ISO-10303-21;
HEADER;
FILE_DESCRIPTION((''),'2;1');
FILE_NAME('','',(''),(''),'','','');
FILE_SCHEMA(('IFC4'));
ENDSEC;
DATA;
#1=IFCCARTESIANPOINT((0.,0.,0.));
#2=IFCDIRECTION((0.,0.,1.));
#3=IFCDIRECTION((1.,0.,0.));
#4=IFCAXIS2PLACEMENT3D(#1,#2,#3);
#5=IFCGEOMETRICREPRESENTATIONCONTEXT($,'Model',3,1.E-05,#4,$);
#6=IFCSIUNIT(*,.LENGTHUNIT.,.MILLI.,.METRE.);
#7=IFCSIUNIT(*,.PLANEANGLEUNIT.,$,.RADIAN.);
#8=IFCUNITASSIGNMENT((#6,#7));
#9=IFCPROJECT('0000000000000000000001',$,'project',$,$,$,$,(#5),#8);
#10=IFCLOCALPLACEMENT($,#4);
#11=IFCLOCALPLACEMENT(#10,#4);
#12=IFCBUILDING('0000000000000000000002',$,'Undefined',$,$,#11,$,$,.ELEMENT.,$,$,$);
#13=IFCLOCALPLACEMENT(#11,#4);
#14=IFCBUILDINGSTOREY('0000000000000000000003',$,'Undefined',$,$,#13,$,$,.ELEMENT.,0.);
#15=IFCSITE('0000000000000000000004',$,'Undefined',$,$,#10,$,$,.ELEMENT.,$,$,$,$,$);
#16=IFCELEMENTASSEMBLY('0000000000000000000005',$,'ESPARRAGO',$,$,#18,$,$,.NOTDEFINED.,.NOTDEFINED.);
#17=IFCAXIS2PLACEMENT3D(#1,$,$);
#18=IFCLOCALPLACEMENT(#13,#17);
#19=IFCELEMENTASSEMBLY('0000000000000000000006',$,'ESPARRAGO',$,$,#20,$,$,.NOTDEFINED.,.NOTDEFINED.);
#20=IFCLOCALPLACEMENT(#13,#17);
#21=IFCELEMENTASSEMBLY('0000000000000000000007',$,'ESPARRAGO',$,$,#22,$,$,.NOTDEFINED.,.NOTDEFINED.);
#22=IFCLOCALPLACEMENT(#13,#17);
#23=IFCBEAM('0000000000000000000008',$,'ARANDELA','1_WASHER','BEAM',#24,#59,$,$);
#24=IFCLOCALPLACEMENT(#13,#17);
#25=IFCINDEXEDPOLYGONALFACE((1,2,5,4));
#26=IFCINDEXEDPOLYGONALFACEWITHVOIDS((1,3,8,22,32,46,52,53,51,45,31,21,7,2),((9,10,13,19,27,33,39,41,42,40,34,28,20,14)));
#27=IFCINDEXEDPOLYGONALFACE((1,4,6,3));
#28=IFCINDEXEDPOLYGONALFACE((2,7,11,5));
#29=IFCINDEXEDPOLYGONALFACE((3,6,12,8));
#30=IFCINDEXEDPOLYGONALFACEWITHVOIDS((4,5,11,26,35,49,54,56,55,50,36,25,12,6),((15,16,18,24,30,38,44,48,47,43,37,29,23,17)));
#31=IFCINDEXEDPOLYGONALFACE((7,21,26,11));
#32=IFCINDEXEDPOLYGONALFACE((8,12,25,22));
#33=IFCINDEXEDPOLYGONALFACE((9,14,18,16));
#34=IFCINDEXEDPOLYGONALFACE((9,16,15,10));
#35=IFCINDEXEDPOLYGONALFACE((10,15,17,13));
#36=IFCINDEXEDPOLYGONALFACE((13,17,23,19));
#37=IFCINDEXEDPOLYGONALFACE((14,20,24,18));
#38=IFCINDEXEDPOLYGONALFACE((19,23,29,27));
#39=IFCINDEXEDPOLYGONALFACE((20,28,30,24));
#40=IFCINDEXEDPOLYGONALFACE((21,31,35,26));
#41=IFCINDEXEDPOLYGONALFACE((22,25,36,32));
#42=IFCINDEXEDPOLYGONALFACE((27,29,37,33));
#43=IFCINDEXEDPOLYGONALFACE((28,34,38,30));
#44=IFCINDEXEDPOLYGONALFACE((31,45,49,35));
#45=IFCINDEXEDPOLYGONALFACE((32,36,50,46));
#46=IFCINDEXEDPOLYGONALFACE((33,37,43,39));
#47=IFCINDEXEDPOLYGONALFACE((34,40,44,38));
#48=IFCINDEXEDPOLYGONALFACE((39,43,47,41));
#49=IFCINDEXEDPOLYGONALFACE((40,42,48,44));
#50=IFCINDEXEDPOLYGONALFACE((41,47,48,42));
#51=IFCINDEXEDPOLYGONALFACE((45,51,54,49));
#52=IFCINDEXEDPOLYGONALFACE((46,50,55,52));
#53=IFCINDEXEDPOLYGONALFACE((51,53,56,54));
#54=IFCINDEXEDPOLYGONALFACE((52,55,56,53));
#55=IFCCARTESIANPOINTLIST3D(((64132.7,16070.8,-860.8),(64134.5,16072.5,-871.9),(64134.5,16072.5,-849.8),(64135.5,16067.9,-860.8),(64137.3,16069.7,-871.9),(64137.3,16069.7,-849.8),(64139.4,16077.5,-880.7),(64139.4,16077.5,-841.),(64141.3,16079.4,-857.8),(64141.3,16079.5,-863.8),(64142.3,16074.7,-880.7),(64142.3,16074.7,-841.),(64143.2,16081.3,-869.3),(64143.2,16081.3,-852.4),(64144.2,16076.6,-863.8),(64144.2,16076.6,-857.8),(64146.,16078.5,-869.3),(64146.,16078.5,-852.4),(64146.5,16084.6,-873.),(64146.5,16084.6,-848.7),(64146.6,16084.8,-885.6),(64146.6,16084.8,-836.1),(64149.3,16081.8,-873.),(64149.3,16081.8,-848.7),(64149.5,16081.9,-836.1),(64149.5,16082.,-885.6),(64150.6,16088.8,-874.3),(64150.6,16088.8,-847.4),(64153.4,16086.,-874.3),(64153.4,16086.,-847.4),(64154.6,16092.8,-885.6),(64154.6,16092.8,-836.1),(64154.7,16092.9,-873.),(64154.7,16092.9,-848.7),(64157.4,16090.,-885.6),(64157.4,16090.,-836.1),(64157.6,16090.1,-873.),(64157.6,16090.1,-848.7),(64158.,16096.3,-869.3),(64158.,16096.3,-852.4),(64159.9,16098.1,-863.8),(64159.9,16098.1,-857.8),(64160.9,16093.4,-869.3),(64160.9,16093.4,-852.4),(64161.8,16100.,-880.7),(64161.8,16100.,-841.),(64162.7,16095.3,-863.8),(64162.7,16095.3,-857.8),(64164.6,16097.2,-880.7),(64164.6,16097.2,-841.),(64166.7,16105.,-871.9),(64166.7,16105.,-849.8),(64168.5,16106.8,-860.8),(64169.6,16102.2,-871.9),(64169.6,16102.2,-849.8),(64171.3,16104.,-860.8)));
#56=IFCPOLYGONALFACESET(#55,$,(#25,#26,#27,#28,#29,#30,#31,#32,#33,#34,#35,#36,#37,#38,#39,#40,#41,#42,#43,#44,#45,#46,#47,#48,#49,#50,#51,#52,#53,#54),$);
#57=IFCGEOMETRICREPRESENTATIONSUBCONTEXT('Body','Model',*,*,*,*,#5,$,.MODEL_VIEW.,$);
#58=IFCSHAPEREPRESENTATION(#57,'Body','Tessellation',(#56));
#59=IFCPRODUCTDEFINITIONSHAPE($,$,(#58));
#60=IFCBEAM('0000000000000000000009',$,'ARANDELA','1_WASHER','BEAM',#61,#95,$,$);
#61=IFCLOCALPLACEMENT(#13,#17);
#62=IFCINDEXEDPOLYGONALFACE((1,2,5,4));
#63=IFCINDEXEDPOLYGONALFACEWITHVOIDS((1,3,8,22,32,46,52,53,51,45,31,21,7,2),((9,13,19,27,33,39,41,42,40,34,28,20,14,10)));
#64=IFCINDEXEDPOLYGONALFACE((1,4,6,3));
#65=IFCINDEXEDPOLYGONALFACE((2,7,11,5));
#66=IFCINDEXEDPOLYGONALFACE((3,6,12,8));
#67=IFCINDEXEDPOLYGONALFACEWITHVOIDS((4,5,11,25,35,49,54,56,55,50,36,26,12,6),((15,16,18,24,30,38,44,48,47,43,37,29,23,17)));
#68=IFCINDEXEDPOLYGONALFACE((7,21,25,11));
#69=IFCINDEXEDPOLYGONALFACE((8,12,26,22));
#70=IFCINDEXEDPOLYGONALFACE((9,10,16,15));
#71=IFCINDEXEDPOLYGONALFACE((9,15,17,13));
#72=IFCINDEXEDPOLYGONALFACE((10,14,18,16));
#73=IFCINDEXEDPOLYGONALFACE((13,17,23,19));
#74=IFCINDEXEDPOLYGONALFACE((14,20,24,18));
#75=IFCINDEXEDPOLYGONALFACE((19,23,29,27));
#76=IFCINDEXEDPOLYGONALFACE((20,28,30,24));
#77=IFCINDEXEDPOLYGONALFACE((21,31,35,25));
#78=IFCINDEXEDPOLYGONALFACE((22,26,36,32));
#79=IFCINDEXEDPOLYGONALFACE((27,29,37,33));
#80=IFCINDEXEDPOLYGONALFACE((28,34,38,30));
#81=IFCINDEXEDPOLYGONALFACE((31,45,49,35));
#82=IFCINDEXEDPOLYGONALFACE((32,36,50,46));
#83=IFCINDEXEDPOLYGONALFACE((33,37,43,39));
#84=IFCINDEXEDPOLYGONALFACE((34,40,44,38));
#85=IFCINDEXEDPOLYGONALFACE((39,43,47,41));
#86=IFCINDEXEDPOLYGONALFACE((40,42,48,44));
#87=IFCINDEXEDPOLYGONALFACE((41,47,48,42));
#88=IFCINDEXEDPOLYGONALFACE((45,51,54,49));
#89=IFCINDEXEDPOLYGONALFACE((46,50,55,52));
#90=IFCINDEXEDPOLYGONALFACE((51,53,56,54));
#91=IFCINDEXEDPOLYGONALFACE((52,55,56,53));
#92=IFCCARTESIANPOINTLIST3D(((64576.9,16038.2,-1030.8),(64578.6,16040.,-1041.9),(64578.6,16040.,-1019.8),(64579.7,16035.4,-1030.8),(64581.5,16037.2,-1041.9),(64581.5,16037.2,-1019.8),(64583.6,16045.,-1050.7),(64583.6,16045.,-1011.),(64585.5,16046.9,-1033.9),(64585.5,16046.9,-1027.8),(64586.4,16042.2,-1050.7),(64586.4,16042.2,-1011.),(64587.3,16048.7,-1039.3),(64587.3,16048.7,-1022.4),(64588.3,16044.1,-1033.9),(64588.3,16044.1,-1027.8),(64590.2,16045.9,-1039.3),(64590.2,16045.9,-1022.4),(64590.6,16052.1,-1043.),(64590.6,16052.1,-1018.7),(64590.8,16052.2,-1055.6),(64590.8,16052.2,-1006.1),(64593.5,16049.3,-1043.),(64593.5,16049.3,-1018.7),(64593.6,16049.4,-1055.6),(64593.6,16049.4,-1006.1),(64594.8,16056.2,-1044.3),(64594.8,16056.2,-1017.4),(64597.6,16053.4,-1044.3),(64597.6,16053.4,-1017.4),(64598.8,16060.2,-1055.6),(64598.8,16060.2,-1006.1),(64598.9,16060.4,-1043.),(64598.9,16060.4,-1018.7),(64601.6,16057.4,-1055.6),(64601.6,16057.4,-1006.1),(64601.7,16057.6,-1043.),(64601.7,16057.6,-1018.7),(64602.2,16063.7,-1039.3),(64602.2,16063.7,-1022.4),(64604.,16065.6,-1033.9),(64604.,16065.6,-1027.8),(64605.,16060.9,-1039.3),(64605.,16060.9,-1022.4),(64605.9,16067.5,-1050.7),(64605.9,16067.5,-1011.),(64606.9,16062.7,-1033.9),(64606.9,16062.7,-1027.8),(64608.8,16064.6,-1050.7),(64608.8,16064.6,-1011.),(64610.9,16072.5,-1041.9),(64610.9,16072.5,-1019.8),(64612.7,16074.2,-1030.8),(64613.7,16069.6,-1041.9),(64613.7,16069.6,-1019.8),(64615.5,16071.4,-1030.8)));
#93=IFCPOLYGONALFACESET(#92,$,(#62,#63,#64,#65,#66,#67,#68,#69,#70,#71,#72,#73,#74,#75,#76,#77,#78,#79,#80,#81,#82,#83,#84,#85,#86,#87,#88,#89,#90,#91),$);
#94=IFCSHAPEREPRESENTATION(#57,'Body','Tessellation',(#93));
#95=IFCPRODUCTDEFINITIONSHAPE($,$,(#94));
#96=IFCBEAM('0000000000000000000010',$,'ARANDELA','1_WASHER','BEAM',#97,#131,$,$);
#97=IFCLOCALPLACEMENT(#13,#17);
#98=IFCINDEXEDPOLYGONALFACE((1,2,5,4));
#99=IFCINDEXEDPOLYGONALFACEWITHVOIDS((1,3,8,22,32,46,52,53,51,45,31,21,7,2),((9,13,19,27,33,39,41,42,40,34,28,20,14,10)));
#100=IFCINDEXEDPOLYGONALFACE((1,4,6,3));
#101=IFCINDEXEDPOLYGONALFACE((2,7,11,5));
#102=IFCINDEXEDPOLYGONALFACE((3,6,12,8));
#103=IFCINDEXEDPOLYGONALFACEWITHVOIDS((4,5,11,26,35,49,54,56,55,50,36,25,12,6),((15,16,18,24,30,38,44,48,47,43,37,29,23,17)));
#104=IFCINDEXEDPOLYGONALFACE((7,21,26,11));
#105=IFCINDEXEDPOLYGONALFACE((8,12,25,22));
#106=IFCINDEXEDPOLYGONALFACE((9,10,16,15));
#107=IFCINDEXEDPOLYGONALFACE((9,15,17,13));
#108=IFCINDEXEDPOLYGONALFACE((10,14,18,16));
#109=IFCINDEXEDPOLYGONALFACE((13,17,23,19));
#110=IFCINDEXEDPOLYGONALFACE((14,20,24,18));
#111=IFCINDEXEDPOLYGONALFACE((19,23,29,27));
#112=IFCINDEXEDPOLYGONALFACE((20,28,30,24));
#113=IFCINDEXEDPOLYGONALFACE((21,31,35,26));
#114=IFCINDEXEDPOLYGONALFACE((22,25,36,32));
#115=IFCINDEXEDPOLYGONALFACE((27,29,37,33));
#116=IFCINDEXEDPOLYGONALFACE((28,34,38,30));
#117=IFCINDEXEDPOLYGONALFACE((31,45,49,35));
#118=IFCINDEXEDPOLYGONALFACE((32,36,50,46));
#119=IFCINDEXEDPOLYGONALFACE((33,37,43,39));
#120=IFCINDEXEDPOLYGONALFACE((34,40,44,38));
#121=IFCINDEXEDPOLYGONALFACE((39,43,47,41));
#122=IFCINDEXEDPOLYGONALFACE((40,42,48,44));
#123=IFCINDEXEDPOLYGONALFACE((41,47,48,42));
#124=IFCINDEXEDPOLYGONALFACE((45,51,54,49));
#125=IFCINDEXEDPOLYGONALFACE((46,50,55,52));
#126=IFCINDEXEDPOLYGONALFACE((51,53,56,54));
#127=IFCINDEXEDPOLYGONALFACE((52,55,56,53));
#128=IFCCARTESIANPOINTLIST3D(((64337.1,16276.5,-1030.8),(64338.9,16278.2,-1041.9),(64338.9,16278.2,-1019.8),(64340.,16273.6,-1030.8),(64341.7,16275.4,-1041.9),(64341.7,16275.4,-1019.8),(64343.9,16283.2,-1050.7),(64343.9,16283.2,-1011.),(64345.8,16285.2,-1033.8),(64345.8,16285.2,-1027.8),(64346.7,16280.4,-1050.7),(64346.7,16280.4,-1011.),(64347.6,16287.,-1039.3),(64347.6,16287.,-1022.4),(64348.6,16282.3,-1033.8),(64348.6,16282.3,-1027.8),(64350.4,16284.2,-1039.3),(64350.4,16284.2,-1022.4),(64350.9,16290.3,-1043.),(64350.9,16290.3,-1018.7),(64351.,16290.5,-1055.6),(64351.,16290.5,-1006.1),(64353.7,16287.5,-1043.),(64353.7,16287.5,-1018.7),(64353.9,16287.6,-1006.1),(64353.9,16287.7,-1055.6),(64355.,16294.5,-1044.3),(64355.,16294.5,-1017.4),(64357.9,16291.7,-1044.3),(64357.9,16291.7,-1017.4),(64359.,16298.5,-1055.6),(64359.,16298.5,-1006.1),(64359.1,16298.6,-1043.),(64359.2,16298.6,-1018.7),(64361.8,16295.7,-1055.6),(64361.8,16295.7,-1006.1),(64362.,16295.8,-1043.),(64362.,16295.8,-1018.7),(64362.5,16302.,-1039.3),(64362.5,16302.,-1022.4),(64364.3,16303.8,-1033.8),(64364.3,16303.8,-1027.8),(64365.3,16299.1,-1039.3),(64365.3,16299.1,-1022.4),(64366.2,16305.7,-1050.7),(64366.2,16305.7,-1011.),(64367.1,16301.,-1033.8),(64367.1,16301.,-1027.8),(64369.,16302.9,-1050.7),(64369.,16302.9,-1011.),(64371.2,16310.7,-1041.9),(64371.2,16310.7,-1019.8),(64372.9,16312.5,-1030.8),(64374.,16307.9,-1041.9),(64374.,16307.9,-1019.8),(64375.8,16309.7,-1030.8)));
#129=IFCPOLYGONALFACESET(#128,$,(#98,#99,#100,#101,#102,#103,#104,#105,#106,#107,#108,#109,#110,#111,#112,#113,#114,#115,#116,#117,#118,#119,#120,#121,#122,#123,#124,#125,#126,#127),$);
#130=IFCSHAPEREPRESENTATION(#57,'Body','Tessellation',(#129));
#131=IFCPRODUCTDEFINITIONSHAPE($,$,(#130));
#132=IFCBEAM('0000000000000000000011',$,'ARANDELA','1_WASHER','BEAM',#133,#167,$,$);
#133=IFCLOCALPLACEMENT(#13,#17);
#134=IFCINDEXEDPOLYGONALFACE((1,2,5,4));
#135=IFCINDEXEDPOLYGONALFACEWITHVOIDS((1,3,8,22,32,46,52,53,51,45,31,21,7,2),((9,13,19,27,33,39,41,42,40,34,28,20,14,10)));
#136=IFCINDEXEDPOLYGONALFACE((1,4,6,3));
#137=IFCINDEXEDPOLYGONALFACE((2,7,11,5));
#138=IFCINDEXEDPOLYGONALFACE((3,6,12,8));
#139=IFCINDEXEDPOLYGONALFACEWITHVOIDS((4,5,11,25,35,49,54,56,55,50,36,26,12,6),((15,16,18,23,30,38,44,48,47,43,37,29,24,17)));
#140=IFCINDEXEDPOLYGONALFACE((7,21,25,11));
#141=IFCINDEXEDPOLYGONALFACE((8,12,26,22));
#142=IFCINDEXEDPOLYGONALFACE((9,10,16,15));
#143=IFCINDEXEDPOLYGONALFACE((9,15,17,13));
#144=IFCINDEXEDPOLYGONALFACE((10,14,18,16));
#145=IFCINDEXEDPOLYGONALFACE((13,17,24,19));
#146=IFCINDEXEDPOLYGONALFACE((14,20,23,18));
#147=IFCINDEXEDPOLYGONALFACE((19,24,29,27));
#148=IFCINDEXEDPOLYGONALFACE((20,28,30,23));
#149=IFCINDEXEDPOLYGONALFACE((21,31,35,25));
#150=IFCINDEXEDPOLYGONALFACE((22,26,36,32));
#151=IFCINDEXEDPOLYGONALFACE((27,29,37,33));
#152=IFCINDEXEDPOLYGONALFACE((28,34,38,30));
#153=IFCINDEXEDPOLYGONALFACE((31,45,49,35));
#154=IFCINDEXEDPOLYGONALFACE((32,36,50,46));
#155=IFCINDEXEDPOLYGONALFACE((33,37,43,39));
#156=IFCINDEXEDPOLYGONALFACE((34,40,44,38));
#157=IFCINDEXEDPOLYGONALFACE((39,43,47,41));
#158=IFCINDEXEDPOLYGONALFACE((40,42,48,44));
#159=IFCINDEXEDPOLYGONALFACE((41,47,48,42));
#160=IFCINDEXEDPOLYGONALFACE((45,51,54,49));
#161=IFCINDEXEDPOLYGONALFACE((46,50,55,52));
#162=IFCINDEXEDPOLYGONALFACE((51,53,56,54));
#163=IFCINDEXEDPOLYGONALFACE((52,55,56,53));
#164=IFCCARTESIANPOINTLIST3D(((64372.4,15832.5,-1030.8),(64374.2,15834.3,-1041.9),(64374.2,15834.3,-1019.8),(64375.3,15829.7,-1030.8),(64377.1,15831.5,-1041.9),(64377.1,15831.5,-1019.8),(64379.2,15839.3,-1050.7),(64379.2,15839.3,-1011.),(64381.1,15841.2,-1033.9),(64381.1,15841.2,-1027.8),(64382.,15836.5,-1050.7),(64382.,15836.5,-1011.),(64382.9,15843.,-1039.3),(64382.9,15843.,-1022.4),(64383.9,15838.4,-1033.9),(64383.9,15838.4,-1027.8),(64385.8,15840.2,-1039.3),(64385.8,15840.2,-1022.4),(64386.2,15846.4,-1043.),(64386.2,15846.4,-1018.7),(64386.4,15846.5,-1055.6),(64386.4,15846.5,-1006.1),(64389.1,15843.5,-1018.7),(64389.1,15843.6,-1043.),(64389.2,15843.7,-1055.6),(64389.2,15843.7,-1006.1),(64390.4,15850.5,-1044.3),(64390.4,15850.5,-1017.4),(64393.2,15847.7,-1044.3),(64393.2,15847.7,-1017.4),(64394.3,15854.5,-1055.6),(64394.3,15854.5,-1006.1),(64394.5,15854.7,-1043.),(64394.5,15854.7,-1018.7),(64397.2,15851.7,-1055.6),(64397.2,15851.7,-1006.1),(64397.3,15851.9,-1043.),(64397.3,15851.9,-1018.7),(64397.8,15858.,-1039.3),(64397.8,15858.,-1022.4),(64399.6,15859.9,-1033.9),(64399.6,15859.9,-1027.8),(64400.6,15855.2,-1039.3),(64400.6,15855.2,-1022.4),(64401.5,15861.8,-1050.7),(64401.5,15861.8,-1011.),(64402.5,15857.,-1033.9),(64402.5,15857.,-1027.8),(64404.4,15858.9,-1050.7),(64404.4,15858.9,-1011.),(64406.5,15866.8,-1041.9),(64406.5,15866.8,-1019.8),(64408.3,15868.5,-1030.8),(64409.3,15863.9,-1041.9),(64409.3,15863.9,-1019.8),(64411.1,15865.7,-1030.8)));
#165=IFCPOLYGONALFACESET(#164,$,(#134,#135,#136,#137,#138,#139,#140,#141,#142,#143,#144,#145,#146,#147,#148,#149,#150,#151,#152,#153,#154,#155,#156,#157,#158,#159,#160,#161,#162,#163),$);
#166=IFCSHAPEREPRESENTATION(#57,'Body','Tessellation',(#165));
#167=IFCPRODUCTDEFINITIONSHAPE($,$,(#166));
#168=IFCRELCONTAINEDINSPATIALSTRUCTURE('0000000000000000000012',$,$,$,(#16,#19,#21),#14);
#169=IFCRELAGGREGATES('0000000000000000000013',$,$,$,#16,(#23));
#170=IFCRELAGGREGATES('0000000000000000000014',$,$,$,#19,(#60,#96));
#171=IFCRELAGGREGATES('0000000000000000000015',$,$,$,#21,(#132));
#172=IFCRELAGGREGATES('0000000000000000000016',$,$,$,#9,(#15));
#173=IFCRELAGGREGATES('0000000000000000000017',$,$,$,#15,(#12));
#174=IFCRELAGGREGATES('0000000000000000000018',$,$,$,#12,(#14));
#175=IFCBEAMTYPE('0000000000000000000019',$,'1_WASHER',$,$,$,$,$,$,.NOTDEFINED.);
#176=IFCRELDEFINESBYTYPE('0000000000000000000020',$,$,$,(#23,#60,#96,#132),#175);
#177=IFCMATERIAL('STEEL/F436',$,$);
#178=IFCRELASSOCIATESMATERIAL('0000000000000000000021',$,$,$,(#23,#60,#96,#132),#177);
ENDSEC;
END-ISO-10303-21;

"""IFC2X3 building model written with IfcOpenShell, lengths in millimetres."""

from ifc_helpers import new_model, si_unit, frame, origin_with_axes, place, context, subcontext, project, spatial, polyline, outline, extrude, material, type_object, element, aggregate, save


model = new_model("IFC2X3")

# Units and contexts
model_context = context("Model", 3, precision=1e-05, world=origin_with_axes())
body_context = subcontext(model_context, "Body", "Model", "MODEL_VIEW")
ifc_project = project(units=[si_unit("LENGTHUNIT", "METRE", prefix="MILLI"), si_unit("PLANEANGLEUNIT", "RADIAN")], contexts=[model_context])

# Site, building, storey
site_placement = place(None, origin_with_axes())
site = spatial("IfcSite", under=ifc_project, at=site_placement, Name="Undefined", CompositionType="ELEMENT")
building_placement = place(site_placement, origin_with_axes())
building = spatial("IfcBuilding", under=site, at=building_placement, Name="Undefined", CompositionType="ELEMENT")
storey_placement = place(building_placement, origin_with_axes())
storey = spatial("IfcBuildingStorey", under=building, at=storey_placement, Name="Undefined", CompositionType="ELEMENT", Elevation=0.0)

# Element assemblies
assembly_1_placement = place(storey_placement, origin_with_axes())
assembly_1 = element("IfcElementAssembly", 1, at=assembly_1_placement, inside=storey, Name="ESPARRAGO", AssemblyPlace="NOTDEFINED", PredefinedType="NOTDEFINED")
assembly_2_placement = place(storey_placement, origin_with_axes())
assembly_2 = element("IfcElementAssembly", 2, at=assembly_2_placement, inside=storey, Name="ESPARRAGO", AssemblyPlace="NOTDEFINED", PredefinedType="NOTDEFINED")
assembly_3_placement = place(storey_placement, origin_with_axes())
assembly_3 = element("IfcElementAssembly", 3, at=assembly_3_placement, inside=storey, Name="ESPARRAGO", AssemblyPlace="NOTDEFINED", PredefinedType="NOTDEFINED")

# Beams
ifc_material_1 = material(Name="STEEL/F436")
beam_type_1 = type_object("IfcBeamType", Name="1_WASHER", PredefinedType="NOTDEFINED")
beam_1_placement = place(assembly_1_placement, frame((64150.6, 16088.8, -860.8), z_axis=(0.000061, -0.000061, 1.0), x_axis=(0.709311, -0.704895, -0.000086)))
beam_1 = element("IfcBeam", 4, at=beam_1_placement, type_object=beam_type_1, material=ifc_material_1, Name="ARANDELA", Description="1_WASHER", ObjectType="BEAM", context=body_context, shape_type="SweptSolid", body=[
    extrude(outline(polyline([(-15.8, -19.9), (-22.9, -11.0), (-25.4, 0.0), (-22.9, 11.0), (-15.8, 19.9), (-5.7, 24.8), (5.7, 24.8), (15.8, 19.9), (22.9, 11.0), (25.4, 0.0), (22.9, -11.0), (15.8, -19.9), (5.7, -24.8), (-5.7, -24.8), (-15.8, -19.9)]), holes=[polyline([(-5.9, 12.2), (-10.5, 8.4), (-13.2, 3.0), (-13.2, -3.0), (-10.5, -8.4), (-5.9, -12.2), (0.0, -13.5), (5.9, -12.2), (10.5, -8.4), (13.2, -3.0), (13.2, 3.0), (10.5, 8.4), (5.9, 12.2), (0.0, 13.5), (-5.9, 12.2)])]), frame((4.0, 0.0, 0.0), z_axis=(-1.0, 0.0, 0.0), x_axis=(0.0, -1.0, 0.0)), (0.0, 0.0, 1.0), 4.0),
])
beam_2_placement = place(assembly_2_placement, frame((64594.8, 16056.2, -1030.8), z_axis=(0.000061, -0.000061, 1.0), x_axis=(0.709311, -0.704895, -0.000086)))
beam_2 = element("IfcBeam", 5, at=beam_2_placement, type_object=beam_type_1, material=ifc_material_1, Name="ARANDELA", Description="1_WASHER", ObjectType="BEAM", context=body_context, shape_type="SweptSolid", body=[
    extrude(outline(polyline([(-15.8, -19.9), (-22.9, -11.0), (-25.4, 0.0), (-22.9, 11.0), (-15.8, 19.9), (-5.7, 24.8), (5.7, 24.8), (15.8, 19.9), (22.9, 11.0), (25.4, 0.0), (22.9, -11.0), (15.8, -19.9), (5.7, -24.8), (-5.7, -24.8), (-15.8, -19.9)]), holes=[polyline([(-5.9, 12.2), (-10.5, 8.4), (-13.2, 3.0), (-13.2, -3.0), (-10.5, -8.4), (-5.9, -12.2), (0.0, -13.5), (5.9, -12.2), (10.5, -8.4), (13.2, -3.0), (13.2, 3.0), (10.5, 8.4), (5.9, 12.2), (0.0, 13.5), (-5.9, 12.2)])]), frame((4.0, 0.0, 0.0), z_axis=(-1.0, 0.0, 0.0), x_axis=(0.0, -1.0, 0.0)), (0.0, 0.0, 1.0), 4.0),
])
beam_3_placement = place(assembly_2_placement, frame((64355.0, 16294.5, -1030.8), z_axis=(0.000061, -0.000061, 1.0), x_axis=(0.709311, -0.704895, -0.000086)))
beam_3 = element("IfcBeam", 6, at=beam_3_placement, type_object=beam_type_1, material=ifc_material_1, Name="ARANDELA", Description="1_WASHER", ObjectType="BEAM", context=body_context, shape_type="SweptSolid", body=[
    extrude(outline(polyline([(-15.8, -19.9), (-22.9, -11.0), (-25.4, 0.0), (-22.9, 11.0), (-15.8, 19.9), (-5.7, 24.8), (5.7, 24.8), (15.8, 19.9), (22.9, 11.0), (25.4, 0.0), (22.9, -11.0), (15.8, -19.9), (5.7, -24.8), (-5.7, -24.8), (-15.8, -19.9)]), holes=[polyline([(-5.9, 12.2), (-10.5, 8.4), (-13.2, 3.0), (-13.2, -3.0), (-10.5, -8.4), (-5.9, -12.2), (0.0, -13.5), (5.9, -12.2), (10.5, -8.4), (13.2, -3.0), (13.2, 3.0), (10.5, 8.4), (5.9, 12.2), (0.0, 13.5), (-5.9, 12.2)])]), frame((4.0, 0.0, 0.0), z_axis=(-1.0, 0.0, 0.0), x_axis=(0.0, -1.0, 0.0)), (0.0, 0.0, 1.0), 4.0),
])
beam_4_placement = place(assembly_3_placement, frame((64390.4, 15850.5, -1030.8), z_axis=(0.000061, -0.000061, 1.0), x_axis=(0.709311, -0.704895, -0.000086)))
beam_4 = element("IfcBeam", 7, at=beam_4_placement, type_object=beam_type_1, material=ifc_material_1, Name="ARANDELA", Description="1_WASHER", ObjectType="BEAM", context=body_context, shape_type="SweptSolid", body=[
    extrude(outline(polyline([(-15.8, -19.9), (-22.9, -11.0), (-25.4, 0.0), (-22.9, 11.0), (-15.8, 19.9), (-5.7, 24.8), (5.7, 24.8), (15.8, 19.9), (22.9, 11.0), (25.4, 0.0), (22.9, -11.0), (15.8, -19.9), (5.7, -24.8), (-5.7, -24.8), (-15.8, -19.9)]), holes=[polyline([(-5.9, 12.2), (-10.5, 8.4), (-13.2, 3.0), (-13.2, -3.0), (-10.5, -8.4), (-5.9, -12.2), (0.0, -13.5), (5.9, -12.2), (10.5, -8.4), (13.2, -3.0), (13.2, 3.0), (10.5, 8.4), (5.9, 12.2), (0.0, 13.5), (-5.9, 12.2)])]), frame((4.0, 0.0, 0.0), z_axis=(-1.0, 0.0, 0.0), x_axis=(0.0, -1.0, 0.0)), (0.0, 0.0, 1.0), 4.0),
])
aggregate(assembly_1, [beam_1])
aggregate(assembly_2, [beam_2, beam_3])
aggregate(assembly_3, [beam_4])

save(model, "model.ifc")
